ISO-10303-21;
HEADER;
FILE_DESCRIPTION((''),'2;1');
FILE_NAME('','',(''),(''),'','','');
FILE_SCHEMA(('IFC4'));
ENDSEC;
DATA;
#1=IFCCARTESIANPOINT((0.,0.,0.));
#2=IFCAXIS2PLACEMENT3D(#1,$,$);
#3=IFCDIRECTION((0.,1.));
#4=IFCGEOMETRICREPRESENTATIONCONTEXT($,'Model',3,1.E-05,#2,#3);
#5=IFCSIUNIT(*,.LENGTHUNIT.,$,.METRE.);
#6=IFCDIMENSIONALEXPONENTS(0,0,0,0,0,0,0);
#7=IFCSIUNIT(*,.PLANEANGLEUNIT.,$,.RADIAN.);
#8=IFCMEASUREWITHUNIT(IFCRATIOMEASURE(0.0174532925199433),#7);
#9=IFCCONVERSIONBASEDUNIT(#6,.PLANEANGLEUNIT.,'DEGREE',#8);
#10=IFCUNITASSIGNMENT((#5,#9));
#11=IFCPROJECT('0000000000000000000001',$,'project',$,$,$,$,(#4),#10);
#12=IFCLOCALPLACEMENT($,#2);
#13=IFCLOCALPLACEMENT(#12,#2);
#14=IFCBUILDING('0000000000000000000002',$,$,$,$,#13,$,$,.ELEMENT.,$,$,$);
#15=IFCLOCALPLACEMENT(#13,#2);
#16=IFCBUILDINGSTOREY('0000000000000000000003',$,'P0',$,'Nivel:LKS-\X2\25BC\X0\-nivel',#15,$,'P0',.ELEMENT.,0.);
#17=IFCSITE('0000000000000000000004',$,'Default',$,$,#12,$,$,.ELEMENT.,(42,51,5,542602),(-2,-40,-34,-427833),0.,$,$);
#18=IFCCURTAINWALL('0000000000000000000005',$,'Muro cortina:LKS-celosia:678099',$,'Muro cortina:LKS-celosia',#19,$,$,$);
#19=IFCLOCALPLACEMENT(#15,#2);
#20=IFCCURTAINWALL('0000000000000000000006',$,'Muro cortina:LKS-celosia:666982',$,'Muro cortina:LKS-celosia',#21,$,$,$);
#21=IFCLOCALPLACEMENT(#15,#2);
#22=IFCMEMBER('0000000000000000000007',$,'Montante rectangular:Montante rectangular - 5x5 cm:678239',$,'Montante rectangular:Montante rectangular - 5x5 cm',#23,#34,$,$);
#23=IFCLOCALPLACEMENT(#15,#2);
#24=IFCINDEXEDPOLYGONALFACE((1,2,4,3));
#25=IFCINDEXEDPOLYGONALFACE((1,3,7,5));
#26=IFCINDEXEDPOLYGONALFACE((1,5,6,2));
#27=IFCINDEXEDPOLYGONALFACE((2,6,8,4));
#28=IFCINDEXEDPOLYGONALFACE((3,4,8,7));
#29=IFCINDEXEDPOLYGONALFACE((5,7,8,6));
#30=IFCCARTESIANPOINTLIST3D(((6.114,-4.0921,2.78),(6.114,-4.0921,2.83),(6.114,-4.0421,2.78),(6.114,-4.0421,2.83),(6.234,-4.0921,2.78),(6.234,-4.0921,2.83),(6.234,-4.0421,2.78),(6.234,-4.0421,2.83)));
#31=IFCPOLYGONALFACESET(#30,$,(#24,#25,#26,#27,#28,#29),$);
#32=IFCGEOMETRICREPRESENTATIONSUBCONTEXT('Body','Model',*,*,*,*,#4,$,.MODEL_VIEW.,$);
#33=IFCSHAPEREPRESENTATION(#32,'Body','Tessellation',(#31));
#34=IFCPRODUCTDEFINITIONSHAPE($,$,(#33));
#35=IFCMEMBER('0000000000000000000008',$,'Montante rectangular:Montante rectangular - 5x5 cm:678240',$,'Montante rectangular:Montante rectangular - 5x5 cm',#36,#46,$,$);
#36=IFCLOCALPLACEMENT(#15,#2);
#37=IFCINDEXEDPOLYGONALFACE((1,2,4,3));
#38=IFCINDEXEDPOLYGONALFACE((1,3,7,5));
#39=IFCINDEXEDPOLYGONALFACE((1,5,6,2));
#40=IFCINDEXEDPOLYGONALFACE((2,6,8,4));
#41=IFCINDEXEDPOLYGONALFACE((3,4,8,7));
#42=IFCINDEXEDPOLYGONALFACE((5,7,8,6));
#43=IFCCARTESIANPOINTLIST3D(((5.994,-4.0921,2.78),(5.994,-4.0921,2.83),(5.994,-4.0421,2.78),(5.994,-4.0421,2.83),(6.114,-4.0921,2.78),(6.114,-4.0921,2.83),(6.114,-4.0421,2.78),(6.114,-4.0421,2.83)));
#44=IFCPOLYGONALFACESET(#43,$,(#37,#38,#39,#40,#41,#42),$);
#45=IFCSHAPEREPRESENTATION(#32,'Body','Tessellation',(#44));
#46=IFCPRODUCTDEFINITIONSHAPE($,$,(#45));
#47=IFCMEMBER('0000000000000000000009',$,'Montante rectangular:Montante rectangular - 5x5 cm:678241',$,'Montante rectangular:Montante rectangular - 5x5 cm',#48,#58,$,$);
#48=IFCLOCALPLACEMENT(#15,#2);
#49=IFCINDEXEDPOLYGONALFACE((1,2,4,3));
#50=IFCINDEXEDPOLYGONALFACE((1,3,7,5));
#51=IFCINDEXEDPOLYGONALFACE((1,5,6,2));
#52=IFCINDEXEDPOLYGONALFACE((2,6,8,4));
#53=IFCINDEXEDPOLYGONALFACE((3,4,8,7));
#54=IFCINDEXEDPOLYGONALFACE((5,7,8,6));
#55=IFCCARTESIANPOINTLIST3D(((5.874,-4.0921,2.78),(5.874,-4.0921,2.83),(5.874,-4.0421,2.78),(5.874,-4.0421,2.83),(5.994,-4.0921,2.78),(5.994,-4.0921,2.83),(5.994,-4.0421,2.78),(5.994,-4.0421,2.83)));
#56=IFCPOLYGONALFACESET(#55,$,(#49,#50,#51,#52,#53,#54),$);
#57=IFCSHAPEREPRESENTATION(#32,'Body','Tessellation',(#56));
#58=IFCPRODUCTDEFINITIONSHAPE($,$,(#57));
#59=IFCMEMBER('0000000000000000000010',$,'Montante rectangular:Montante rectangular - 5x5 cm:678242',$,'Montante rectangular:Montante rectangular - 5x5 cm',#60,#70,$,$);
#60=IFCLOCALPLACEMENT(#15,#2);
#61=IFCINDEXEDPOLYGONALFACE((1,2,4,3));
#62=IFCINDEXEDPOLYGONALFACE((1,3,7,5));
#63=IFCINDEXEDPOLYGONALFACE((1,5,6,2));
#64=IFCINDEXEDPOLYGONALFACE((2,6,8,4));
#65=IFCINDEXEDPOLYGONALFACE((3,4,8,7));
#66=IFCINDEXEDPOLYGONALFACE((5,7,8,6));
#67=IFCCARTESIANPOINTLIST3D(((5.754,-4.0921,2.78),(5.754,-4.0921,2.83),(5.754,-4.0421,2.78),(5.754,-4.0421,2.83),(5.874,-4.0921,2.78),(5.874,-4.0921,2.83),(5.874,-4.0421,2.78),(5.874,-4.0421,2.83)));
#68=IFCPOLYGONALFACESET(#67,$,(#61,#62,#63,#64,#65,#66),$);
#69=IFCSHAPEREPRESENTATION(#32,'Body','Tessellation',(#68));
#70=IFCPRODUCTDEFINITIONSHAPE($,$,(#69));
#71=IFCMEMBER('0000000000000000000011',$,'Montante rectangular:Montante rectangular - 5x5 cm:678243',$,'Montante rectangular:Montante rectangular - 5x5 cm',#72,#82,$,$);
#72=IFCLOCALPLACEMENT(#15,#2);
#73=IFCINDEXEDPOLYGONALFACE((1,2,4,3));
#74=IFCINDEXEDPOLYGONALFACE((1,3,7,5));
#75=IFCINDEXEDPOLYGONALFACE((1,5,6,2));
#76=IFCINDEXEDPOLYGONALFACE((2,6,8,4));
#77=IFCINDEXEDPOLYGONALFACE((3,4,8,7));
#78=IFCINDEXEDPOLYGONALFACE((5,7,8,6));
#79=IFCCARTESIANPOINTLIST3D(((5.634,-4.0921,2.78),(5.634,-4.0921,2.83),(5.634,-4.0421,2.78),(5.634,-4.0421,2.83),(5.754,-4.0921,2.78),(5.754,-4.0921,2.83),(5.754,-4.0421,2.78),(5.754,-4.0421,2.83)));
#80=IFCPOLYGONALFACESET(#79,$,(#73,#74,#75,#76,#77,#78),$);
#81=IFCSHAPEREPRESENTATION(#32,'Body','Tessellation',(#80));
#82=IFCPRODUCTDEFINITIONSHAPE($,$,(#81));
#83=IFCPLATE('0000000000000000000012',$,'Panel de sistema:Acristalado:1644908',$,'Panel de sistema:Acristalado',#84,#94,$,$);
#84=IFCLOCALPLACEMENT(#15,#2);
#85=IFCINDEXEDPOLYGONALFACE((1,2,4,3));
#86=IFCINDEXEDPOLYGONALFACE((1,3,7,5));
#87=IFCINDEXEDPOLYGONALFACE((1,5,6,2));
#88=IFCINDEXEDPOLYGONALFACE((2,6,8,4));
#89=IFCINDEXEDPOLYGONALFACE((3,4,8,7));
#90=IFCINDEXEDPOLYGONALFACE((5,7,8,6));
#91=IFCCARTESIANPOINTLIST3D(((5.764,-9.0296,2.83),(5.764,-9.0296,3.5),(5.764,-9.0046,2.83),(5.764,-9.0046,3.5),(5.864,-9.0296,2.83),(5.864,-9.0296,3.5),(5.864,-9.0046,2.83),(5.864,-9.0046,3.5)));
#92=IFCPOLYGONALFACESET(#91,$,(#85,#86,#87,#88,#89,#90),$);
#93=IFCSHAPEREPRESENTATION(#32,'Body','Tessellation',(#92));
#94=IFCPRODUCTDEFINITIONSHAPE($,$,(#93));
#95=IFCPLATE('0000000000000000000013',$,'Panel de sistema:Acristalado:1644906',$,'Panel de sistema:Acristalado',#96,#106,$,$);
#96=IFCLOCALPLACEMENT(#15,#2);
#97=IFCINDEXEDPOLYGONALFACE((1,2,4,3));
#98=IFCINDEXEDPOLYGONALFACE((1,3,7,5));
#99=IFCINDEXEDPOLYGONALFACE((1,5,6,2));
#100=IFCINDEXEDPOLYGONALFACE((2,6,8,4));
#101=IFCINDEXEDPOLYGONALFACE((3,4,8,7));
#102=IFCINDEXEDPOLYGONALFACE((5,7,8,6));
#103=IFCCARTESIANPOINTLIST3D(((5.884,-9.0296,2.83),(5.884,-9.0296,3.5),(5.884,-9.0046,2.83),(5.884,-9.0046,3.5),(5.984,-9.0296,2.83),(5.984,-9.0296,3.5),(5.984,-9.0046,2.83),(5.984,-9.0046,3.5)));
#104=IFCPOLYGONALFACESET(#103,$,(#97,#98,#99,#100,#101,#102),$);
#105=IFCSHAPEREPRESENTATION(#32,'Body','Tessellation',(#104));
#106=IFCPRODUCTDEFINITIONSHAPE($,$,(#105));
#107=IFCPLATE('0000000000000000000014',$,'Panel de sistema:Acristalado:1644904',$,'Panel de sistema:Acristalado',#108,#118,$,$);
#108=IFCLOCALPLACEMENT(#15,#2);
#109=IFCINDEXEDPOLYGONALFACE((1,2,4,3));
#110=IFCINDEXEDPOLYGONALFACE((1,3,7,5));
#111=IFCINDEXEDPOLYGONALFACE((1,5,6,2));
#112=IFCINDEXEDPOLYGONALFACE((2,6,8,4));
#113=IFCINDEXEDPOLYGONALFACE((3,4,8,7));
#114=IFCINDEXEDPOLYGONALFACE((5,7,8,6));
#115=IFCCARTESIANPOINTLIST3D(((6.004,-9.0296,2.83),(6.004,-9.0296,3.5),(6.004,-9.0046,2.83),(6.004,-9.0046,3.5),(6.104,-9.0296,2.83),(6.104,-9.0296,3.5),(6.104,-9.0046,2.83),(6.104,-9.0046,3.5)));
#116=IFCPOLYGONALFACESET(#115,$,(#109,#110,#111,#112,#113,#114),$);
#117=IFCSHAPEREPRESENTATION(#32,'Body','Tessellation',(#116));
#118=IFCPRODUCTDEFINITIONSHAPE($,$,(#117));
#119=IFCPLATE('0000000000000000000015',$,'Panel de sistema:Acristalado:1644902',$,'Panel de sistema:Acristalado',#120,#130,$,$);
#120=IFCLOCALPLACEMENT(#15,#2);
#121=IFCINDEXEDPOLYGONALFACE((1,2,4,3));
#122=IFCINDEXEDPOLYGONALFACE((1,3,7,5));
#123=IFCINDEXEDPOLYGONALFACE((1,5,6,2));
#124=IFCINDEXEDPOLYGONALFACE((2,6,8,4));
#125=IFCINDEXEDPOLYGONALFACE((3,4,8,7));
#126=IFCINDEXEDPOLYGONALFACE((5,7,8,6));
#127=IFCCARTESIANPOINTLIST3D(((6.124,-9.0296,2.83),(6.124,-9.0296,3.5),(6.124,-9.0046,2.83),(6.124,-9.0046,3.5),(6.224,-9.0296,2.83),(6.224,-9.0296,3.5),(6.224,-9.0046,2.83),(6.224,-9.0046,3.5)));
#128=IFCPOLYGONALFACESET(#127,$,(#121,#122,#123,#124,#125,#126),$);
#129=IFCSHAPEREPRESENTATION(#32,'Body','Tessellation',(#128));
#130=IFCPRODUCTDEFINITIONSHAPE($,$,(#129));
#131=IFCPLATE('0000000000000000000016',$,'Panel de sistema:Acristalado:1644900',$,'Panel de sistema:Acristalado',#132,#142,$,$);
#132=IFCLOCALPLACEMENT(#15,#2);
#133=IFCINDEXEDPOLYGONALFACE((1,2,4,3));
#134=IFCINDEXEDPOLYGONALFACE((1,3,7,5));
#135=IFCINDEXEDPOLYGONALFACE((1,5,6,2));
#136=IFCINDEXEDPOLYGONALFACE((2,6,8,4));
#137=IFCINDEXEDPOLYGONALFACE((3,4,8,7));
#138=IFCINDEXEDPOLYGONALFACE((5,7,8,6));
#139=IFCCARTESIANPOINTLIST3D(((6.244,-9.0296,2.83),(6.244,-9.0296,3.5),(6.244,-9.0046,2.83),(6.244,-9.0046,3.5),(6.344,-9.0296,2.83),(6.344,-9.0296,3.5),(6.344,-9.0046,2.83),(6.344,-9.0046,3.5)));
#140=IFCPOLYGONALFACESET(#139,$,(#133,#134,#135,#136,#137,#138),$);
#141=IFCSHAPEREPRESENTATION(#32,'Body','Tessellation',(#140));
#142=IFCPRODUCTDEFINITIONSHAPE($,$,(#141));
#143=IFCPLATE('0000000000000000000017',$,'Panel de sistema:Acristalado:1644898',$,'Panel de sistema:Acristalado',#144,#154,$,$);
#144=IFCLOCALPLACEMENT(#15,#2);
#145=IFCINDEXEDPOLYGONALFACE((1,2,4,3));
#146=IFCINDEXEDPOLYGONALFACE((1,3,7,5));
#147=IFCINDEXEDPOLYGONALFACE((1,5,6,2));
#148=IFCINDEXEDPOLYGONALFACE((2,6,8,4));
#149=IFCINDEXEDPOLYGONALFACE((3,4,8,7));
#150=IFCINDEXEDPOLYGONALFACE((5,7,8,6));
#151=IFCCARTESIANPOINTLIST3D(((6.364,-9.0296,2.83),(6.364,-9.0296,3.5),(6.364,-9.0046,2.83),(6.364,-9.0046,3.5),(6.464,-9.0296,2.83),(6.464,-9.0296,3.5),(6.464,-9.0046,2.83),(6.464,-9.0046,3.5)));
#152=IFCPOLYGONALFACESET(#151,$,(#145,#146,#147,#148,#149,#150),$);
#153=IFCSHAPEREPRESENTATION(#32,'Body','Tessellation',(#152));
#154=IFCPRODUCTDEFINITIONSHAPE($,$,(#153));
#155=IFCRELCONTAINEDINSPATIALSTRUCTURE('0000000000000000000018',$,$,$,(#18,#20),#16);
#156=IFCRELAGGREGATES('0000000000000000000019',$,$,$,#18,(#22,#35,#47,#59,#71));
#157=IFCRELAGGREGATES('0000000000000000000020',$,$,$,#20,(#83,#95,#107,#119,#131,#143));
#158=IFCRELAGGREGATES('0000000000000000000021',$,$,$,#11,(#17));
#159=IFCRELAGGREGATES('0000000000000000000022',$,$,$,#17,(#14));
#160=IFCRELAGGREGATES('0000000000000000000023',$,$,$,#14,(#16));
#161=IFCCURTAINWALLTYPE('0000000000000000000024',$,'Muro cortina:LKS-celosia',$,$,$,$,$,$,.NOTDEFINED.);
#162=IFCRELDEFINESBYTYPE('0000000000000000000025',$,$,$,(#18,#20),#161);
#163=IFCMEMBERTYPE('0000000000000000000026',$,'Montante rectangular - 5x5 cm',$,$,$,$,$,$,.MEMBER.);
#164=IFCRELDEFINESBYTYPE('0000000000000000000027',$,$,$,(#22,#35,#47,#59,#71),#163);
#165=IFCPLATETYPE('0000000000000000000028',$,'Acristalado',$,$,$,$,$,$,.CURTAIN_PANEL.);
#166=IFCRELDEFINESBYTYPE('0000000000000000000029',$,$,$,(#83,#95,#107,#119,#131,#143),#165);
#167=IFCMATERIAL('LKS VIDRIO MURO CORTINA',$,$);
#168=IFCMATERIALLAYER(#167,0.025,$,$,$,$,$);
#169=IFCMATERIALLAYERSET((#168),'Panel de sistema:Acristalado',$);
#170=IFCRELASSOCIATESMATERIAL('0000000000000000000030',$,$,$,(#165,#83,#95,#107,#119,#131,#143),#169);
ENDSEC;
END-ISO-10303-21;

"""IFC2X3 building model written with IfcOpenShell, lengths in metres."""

from ifc_helpers import new_model, entity, si_unit, converted_unit, direction, frame, origin, origin_2d_with_axis, place, context, subcontext, project, spatial, rectangle, extrude, source, transform, mapped, material, layer, layer_set, layer_usage, type_object, type_shapes, element, aggregate, save


model = new_model("IFC2X3")

# Units and contexts
model_context = context("Model", 3, precision=1e-05, world=origin(), true_north=direction((0.0, 1.0)))
body_context = subcontext(model_context, "Body", "Model", "MODEL_VIEW")
ifc_project = project(units=[si_unit("LENGTHUNIT", "METRE"), converted_unit("PLANEANGLEUNIT", "DEGREE", entity("IfcRatioMeasure", 0.0174532925199433), si_unit("PLANEANGLEUNIT", "RADIAN"), dimensions=[0, 0, 0, 0, 0, 0, 0])], contexts=[model_context])

# Site, building, storey
site_placement = place(None, origin())
site = spatial("IfcSite", under=ifc_project, at=site_placement, Name="Default", CompositionType="ELEMENT", RefLatitude=(42, 51, 5, 542602), RefLongitude=(-2, -40, -34, -427833), RefElevation=0.0)
building_placement = place(site_placement, origin())
building = spatial("IfcBuilding", under=site, at=building_placement, CompositionType="ELEMENT")
storey_placement = place(building_placement, origin())
storey = spatial("IfcBuildingStorey", under=building, at=storey_placement, Name="P0", ObjectType="Nivel:LKS-▼-nivel", LongName="P0", CompositionType="ELEMENT", Elevation=0.0)

# Curtain wall
curtain_wall_type = type_object("IfcCurtainWallType", Name="Muro cortina:LKS-celosia", PredefinedType="NOTDEFINED")
curtain_wall_1_placement = place(storey_placement, origin())
curtain_wall_1 = element("IfcCurtainWall", 1, at=curtain_wall_1_placement, inside=storey, type_object=curtain_wall_type, Name="Muro cortina:LKS-celosia:678099", ObjectType="Muro cortina:LKS-celosia")

# Curtain wall
curtain_wall_2_placement = place(storey_placement, origin())
curtain_wall_2 = element("IfcCurtainWall", 2, at=curtain_wall_2_placement, inside=storey, type_object=curtain_wall_type, Name="Muro cortina:LKS-celosia:666982", ObjectType="Muro cortina:LKS-celosia")
member_type_1 = type_object("IfcMemberType", Name="Montante rectangular - 5x5 cm", PredefinedType="MEMBER")
shared_shape_1 = source(origin(), body_context, "Body", "SweptSolid", [
    extrude(rectangle(XDim=0.05, YDim=0.05, at=origin_2d_with_axis()), frame((-0.025, -0.1, -0.12), z_axis=(0.0, 0.0, 1.0), x_axis=(0.0, -1.0, 0.0)), (0.0, 0.0, 1.0), 0.12),
])
type_shapes(member_type_1, [shared_shape_1])

# Members
member_1_placement = place(storey_placement, frame((6.114, -4.1671, 2.78), z_axis=(-1.0, 0.0, 0.0), x_axis=(0.0, 0.0, -1.0)))
member_1 = element("IfcMember", 3, at=member_1_placement, type_object=member_type_1, Name="Montante rectangular:Montante rectangular - 5x5 cm:678239", ObjectType="Montante rectangular:Montante rectangular - 5x5 cm", context=body_context, shape_type="MappedRepresentation", body=[
    mapped(shared_shape_1, transform((0.0, 0.0, 0.0), scale=1.0)),
])
member_2_placement = place(storey_placement, frame((5.994, -4.1671, 2.78), z_axis=(-1.0, 0.0, 0.0), x_axis=(0.0, 0.0, -1.0)))
member_2 = element("IfcMember", 4, at=member_2_placement, type_object=member_type_1, Name="Montante rectangular:Montante rectangular - 5x5 cm:678240", ObjectType="Montante rectangular:Montante rectangular - 5x5 cm", context=body_context, shape_type="MappedRepresentation", body=[
    mapped(shared_shape_1, transform((0.0, 0.0, 0.0), scale=1.0)),
])
member_3_placement = place(storey_placement, frame((5.874, -4.1671, 2.78), z_axis=(-1.0, 0.0, 0.0), x_axis=(0.0, 0.0, -1.0)))
member_3 = element("IfcMember", 5, at=member_3_placement, type_object=member_type_1, Name="Montante rectangular:Montante rectangular - 5x5 cm:678241", ObjectType="Montante rectangular:Montante rectangular - 5x5 cm", context=body_context, shape_type="MappedRepresentation", body=[
    mapped(shared_shape_1, transform((0.0, 0.0, 0.0), scale=1.0)),
])
member_4_placement = place(storey_placement, frame((5.754, -4.1671, 2.78), z_axis=(-1.0, 0.0, 0.0), x_axis=(0.0, 0.0, -1.0)))
member_4 = element("IfcMember", 6, at=member_4_placement, type_object=member_type_1, Name="Montante rectangular:Montante rectangular - 5x5 cm:678242", ObjectType="Montante rectangular:Montante rectangular - 5x5 cm", context=body_context, shape_type="MappedRepresentation", body=[
    mapped(shared_shape_1, transform((0.0, 0.0, 0.0), scale=1.0)),
])
member_5_placement = place(storey_placement, frame((5.634, -4.1671, 2.78), z_axis=(-1.0, 0.0, 0.0), x_axis=(0.0, 0.0, -1.0)))
member_5 = element("IfcMember", 7, at=member_5_placement, type_object=member_type_1, Name="Montante rectangular:Montante rectangular - 5x5 cm:678243", ObjectType="Montante rectangular:Montante rectangular - 5x5 cm", context=body_context, shape_type="MappedRepresentation", body=[
    mapped(shared_shape_1, transform((0.0, 0.0, 0.0), scale=1.0)),
])
aggregate(curtain_wall_1, [member_1, member_2, member_3, member_4, member_5])

# Plates
ifc_material_1 = material(Name="LKS VIDRIO MURO CORTINA")
ifc_layer_1 = layer(ifc_material_1, 0.025)
ifc_layer_set_1 = layer_set([ifc_layer_1], Name="Panel de sistema:Acristalado")
ifc_layer_usage_1 = layer_usage(ifc_layer_set_1, "AXIS3", "POSITIVE", 0.0)
plate_type = type_object("IfcPlateType", Name="Acristalado", PredefinedType="CURTAIN_PANEL", material=ifc_layer_set_1)
shared_shape_2 = source(origin(), body_context, "Body", "SweptSolid", [
    extrude(rectangle(XDim=0.025, YDim=0.1, at=origin_2d_with_axis()), frame((0.0, 0.0, 0.0), z_axis=(0.0, 0.0, 1.0), x_axis=(0.0, 1.0, 0.0)), (0.0, 0.0, 1.0), 0.67),
])
type_shapes(plate_type, [shared_shape_2])
plate_1_placement = place(curtain_wall_2_placement, frame((5.814, -9.0171, 2.83)))
plate_1 = element("IfcPlate", 8, at=plate_1_placement, type_object=plate_type, material=ifc_layer_usage_1, Name="Panel de sistema:Acristalado:1644908", ObjectType="Panel de sistema:Acristalado", context=body_context, shape_type="MappedRepresentation", body=[
    mapped(shared_shape_2, transform((0.0, 0.0, 0.0), scale=1.0)),
])
ifc_layer_usage_2 = layer_usage(ifc_layer_set_1, "AXIS3", "POSITIVE", 0.0)
plate_2_placement = place(curtain_wall_2_placement, frame((5.934, -9.0171, 2.83)))
plate_2 = element("IfcPlate", 9, at=plate_2_placement, type_object=plate_type, material=ifc_layer_usage_2, Name="Panel de sistema:Acristalado:1644906", ObjectType="Panel de sistema:Acristalado", context=body_context, shape_type="MappedRepresentation", body=[
    mapped(shared_shape_2, transform((0.0, 0.0, 0.0), scale=1.0)),
])
ifc_layer_usage_3 = layer_usage(ifc_layer_set_1, "AXIS3", "POSITIVE", 0.0)
plate_3_placement = place(curtain_wall_2_placement, frame((6.054, -9.0171, 2.83)))
plate_3 = element("IfcPlate", 10, at=plate_3_placement, type_object=plate_type, material=ifc_layer_usage_3, Name="Panel de sistema:Acristalado:1644904", ObjectType="Panel de sistema:Acristalado", context=body_context, shape_type="MappedRepresentation", body=[
    mapped(shared_shape_2, transform((0.0, 0.0, 0.0), scale=1.0)),
])
ifc_layer_usage_4 = layer_usage(ifc_layer_set_1, "AXIS3", "POSITIVE", 0.0)
plate_4_placement = place(curtain_wall_2_placement, frame((6.174, -9.0171, 2.83)))
plate_4 = element("IfcPlate", 11, at=plate_4_placement, type_object=plate_type, material=ifc_layer_usage_4, Name="Panel de sistema:Acristalado:1644902", ObjectType="Panel de sistema:Acristalado", context=body_context, shape_type="MappedRepresentation", body=[
    mapped(shared_shape_2, transform((0.0, 0.0, 0.0), scale=1.0)),
])
ifc_layer_usage_5 = layer_usage(ifc_layer_set_1, "AXIS3", "POSITIVE", 0.0)
plate_5_placement = place(curtain_wall_2_placement, frame((6.294, -9.0171, 2.83)))
plate_5 = element("IfcPlate", 12, at=plate_5_placement, type_object=plate_type, material=ifc_layer_usage_5, Name="Panel de sistema:Acristalado:1644900", ObjectType="Panel de sistema:Acristalado", context=body_context, shape_type="MappedRepresentation", body=[
    mapped(shared_shape_2, transform((0.0, 0.0, 0.0), scale=1.0)),
])
ifc_layer_usage_6 = layer_usage(ifc_layer_set_1, "AXIS3", "POSITIVE", 0.0)
plate_6_placement = place(curtain_wall_2_placement, frame((6.414, -9.0171, 2.83)))
plate_6 = element("IfcPlate", 13, at=plate_6_placement, type_object=plate_type, material=ifc_layer_usage_6, Name="Panel de sistema:Acristalado:1644898", ObjectType="Panel de sistema:Acristalado", context=body_context, shape_type="MappedRepresentation", body=[
    mapped(shared_shape_2, transform((0.0, 0.0, 0.0), scale=1.0)),
])
aggregate(curtain_wall_2, [plate_1, plate_2, plate_3, plate_4, plate_5, plate_6])

save(model, "model.ifc")
